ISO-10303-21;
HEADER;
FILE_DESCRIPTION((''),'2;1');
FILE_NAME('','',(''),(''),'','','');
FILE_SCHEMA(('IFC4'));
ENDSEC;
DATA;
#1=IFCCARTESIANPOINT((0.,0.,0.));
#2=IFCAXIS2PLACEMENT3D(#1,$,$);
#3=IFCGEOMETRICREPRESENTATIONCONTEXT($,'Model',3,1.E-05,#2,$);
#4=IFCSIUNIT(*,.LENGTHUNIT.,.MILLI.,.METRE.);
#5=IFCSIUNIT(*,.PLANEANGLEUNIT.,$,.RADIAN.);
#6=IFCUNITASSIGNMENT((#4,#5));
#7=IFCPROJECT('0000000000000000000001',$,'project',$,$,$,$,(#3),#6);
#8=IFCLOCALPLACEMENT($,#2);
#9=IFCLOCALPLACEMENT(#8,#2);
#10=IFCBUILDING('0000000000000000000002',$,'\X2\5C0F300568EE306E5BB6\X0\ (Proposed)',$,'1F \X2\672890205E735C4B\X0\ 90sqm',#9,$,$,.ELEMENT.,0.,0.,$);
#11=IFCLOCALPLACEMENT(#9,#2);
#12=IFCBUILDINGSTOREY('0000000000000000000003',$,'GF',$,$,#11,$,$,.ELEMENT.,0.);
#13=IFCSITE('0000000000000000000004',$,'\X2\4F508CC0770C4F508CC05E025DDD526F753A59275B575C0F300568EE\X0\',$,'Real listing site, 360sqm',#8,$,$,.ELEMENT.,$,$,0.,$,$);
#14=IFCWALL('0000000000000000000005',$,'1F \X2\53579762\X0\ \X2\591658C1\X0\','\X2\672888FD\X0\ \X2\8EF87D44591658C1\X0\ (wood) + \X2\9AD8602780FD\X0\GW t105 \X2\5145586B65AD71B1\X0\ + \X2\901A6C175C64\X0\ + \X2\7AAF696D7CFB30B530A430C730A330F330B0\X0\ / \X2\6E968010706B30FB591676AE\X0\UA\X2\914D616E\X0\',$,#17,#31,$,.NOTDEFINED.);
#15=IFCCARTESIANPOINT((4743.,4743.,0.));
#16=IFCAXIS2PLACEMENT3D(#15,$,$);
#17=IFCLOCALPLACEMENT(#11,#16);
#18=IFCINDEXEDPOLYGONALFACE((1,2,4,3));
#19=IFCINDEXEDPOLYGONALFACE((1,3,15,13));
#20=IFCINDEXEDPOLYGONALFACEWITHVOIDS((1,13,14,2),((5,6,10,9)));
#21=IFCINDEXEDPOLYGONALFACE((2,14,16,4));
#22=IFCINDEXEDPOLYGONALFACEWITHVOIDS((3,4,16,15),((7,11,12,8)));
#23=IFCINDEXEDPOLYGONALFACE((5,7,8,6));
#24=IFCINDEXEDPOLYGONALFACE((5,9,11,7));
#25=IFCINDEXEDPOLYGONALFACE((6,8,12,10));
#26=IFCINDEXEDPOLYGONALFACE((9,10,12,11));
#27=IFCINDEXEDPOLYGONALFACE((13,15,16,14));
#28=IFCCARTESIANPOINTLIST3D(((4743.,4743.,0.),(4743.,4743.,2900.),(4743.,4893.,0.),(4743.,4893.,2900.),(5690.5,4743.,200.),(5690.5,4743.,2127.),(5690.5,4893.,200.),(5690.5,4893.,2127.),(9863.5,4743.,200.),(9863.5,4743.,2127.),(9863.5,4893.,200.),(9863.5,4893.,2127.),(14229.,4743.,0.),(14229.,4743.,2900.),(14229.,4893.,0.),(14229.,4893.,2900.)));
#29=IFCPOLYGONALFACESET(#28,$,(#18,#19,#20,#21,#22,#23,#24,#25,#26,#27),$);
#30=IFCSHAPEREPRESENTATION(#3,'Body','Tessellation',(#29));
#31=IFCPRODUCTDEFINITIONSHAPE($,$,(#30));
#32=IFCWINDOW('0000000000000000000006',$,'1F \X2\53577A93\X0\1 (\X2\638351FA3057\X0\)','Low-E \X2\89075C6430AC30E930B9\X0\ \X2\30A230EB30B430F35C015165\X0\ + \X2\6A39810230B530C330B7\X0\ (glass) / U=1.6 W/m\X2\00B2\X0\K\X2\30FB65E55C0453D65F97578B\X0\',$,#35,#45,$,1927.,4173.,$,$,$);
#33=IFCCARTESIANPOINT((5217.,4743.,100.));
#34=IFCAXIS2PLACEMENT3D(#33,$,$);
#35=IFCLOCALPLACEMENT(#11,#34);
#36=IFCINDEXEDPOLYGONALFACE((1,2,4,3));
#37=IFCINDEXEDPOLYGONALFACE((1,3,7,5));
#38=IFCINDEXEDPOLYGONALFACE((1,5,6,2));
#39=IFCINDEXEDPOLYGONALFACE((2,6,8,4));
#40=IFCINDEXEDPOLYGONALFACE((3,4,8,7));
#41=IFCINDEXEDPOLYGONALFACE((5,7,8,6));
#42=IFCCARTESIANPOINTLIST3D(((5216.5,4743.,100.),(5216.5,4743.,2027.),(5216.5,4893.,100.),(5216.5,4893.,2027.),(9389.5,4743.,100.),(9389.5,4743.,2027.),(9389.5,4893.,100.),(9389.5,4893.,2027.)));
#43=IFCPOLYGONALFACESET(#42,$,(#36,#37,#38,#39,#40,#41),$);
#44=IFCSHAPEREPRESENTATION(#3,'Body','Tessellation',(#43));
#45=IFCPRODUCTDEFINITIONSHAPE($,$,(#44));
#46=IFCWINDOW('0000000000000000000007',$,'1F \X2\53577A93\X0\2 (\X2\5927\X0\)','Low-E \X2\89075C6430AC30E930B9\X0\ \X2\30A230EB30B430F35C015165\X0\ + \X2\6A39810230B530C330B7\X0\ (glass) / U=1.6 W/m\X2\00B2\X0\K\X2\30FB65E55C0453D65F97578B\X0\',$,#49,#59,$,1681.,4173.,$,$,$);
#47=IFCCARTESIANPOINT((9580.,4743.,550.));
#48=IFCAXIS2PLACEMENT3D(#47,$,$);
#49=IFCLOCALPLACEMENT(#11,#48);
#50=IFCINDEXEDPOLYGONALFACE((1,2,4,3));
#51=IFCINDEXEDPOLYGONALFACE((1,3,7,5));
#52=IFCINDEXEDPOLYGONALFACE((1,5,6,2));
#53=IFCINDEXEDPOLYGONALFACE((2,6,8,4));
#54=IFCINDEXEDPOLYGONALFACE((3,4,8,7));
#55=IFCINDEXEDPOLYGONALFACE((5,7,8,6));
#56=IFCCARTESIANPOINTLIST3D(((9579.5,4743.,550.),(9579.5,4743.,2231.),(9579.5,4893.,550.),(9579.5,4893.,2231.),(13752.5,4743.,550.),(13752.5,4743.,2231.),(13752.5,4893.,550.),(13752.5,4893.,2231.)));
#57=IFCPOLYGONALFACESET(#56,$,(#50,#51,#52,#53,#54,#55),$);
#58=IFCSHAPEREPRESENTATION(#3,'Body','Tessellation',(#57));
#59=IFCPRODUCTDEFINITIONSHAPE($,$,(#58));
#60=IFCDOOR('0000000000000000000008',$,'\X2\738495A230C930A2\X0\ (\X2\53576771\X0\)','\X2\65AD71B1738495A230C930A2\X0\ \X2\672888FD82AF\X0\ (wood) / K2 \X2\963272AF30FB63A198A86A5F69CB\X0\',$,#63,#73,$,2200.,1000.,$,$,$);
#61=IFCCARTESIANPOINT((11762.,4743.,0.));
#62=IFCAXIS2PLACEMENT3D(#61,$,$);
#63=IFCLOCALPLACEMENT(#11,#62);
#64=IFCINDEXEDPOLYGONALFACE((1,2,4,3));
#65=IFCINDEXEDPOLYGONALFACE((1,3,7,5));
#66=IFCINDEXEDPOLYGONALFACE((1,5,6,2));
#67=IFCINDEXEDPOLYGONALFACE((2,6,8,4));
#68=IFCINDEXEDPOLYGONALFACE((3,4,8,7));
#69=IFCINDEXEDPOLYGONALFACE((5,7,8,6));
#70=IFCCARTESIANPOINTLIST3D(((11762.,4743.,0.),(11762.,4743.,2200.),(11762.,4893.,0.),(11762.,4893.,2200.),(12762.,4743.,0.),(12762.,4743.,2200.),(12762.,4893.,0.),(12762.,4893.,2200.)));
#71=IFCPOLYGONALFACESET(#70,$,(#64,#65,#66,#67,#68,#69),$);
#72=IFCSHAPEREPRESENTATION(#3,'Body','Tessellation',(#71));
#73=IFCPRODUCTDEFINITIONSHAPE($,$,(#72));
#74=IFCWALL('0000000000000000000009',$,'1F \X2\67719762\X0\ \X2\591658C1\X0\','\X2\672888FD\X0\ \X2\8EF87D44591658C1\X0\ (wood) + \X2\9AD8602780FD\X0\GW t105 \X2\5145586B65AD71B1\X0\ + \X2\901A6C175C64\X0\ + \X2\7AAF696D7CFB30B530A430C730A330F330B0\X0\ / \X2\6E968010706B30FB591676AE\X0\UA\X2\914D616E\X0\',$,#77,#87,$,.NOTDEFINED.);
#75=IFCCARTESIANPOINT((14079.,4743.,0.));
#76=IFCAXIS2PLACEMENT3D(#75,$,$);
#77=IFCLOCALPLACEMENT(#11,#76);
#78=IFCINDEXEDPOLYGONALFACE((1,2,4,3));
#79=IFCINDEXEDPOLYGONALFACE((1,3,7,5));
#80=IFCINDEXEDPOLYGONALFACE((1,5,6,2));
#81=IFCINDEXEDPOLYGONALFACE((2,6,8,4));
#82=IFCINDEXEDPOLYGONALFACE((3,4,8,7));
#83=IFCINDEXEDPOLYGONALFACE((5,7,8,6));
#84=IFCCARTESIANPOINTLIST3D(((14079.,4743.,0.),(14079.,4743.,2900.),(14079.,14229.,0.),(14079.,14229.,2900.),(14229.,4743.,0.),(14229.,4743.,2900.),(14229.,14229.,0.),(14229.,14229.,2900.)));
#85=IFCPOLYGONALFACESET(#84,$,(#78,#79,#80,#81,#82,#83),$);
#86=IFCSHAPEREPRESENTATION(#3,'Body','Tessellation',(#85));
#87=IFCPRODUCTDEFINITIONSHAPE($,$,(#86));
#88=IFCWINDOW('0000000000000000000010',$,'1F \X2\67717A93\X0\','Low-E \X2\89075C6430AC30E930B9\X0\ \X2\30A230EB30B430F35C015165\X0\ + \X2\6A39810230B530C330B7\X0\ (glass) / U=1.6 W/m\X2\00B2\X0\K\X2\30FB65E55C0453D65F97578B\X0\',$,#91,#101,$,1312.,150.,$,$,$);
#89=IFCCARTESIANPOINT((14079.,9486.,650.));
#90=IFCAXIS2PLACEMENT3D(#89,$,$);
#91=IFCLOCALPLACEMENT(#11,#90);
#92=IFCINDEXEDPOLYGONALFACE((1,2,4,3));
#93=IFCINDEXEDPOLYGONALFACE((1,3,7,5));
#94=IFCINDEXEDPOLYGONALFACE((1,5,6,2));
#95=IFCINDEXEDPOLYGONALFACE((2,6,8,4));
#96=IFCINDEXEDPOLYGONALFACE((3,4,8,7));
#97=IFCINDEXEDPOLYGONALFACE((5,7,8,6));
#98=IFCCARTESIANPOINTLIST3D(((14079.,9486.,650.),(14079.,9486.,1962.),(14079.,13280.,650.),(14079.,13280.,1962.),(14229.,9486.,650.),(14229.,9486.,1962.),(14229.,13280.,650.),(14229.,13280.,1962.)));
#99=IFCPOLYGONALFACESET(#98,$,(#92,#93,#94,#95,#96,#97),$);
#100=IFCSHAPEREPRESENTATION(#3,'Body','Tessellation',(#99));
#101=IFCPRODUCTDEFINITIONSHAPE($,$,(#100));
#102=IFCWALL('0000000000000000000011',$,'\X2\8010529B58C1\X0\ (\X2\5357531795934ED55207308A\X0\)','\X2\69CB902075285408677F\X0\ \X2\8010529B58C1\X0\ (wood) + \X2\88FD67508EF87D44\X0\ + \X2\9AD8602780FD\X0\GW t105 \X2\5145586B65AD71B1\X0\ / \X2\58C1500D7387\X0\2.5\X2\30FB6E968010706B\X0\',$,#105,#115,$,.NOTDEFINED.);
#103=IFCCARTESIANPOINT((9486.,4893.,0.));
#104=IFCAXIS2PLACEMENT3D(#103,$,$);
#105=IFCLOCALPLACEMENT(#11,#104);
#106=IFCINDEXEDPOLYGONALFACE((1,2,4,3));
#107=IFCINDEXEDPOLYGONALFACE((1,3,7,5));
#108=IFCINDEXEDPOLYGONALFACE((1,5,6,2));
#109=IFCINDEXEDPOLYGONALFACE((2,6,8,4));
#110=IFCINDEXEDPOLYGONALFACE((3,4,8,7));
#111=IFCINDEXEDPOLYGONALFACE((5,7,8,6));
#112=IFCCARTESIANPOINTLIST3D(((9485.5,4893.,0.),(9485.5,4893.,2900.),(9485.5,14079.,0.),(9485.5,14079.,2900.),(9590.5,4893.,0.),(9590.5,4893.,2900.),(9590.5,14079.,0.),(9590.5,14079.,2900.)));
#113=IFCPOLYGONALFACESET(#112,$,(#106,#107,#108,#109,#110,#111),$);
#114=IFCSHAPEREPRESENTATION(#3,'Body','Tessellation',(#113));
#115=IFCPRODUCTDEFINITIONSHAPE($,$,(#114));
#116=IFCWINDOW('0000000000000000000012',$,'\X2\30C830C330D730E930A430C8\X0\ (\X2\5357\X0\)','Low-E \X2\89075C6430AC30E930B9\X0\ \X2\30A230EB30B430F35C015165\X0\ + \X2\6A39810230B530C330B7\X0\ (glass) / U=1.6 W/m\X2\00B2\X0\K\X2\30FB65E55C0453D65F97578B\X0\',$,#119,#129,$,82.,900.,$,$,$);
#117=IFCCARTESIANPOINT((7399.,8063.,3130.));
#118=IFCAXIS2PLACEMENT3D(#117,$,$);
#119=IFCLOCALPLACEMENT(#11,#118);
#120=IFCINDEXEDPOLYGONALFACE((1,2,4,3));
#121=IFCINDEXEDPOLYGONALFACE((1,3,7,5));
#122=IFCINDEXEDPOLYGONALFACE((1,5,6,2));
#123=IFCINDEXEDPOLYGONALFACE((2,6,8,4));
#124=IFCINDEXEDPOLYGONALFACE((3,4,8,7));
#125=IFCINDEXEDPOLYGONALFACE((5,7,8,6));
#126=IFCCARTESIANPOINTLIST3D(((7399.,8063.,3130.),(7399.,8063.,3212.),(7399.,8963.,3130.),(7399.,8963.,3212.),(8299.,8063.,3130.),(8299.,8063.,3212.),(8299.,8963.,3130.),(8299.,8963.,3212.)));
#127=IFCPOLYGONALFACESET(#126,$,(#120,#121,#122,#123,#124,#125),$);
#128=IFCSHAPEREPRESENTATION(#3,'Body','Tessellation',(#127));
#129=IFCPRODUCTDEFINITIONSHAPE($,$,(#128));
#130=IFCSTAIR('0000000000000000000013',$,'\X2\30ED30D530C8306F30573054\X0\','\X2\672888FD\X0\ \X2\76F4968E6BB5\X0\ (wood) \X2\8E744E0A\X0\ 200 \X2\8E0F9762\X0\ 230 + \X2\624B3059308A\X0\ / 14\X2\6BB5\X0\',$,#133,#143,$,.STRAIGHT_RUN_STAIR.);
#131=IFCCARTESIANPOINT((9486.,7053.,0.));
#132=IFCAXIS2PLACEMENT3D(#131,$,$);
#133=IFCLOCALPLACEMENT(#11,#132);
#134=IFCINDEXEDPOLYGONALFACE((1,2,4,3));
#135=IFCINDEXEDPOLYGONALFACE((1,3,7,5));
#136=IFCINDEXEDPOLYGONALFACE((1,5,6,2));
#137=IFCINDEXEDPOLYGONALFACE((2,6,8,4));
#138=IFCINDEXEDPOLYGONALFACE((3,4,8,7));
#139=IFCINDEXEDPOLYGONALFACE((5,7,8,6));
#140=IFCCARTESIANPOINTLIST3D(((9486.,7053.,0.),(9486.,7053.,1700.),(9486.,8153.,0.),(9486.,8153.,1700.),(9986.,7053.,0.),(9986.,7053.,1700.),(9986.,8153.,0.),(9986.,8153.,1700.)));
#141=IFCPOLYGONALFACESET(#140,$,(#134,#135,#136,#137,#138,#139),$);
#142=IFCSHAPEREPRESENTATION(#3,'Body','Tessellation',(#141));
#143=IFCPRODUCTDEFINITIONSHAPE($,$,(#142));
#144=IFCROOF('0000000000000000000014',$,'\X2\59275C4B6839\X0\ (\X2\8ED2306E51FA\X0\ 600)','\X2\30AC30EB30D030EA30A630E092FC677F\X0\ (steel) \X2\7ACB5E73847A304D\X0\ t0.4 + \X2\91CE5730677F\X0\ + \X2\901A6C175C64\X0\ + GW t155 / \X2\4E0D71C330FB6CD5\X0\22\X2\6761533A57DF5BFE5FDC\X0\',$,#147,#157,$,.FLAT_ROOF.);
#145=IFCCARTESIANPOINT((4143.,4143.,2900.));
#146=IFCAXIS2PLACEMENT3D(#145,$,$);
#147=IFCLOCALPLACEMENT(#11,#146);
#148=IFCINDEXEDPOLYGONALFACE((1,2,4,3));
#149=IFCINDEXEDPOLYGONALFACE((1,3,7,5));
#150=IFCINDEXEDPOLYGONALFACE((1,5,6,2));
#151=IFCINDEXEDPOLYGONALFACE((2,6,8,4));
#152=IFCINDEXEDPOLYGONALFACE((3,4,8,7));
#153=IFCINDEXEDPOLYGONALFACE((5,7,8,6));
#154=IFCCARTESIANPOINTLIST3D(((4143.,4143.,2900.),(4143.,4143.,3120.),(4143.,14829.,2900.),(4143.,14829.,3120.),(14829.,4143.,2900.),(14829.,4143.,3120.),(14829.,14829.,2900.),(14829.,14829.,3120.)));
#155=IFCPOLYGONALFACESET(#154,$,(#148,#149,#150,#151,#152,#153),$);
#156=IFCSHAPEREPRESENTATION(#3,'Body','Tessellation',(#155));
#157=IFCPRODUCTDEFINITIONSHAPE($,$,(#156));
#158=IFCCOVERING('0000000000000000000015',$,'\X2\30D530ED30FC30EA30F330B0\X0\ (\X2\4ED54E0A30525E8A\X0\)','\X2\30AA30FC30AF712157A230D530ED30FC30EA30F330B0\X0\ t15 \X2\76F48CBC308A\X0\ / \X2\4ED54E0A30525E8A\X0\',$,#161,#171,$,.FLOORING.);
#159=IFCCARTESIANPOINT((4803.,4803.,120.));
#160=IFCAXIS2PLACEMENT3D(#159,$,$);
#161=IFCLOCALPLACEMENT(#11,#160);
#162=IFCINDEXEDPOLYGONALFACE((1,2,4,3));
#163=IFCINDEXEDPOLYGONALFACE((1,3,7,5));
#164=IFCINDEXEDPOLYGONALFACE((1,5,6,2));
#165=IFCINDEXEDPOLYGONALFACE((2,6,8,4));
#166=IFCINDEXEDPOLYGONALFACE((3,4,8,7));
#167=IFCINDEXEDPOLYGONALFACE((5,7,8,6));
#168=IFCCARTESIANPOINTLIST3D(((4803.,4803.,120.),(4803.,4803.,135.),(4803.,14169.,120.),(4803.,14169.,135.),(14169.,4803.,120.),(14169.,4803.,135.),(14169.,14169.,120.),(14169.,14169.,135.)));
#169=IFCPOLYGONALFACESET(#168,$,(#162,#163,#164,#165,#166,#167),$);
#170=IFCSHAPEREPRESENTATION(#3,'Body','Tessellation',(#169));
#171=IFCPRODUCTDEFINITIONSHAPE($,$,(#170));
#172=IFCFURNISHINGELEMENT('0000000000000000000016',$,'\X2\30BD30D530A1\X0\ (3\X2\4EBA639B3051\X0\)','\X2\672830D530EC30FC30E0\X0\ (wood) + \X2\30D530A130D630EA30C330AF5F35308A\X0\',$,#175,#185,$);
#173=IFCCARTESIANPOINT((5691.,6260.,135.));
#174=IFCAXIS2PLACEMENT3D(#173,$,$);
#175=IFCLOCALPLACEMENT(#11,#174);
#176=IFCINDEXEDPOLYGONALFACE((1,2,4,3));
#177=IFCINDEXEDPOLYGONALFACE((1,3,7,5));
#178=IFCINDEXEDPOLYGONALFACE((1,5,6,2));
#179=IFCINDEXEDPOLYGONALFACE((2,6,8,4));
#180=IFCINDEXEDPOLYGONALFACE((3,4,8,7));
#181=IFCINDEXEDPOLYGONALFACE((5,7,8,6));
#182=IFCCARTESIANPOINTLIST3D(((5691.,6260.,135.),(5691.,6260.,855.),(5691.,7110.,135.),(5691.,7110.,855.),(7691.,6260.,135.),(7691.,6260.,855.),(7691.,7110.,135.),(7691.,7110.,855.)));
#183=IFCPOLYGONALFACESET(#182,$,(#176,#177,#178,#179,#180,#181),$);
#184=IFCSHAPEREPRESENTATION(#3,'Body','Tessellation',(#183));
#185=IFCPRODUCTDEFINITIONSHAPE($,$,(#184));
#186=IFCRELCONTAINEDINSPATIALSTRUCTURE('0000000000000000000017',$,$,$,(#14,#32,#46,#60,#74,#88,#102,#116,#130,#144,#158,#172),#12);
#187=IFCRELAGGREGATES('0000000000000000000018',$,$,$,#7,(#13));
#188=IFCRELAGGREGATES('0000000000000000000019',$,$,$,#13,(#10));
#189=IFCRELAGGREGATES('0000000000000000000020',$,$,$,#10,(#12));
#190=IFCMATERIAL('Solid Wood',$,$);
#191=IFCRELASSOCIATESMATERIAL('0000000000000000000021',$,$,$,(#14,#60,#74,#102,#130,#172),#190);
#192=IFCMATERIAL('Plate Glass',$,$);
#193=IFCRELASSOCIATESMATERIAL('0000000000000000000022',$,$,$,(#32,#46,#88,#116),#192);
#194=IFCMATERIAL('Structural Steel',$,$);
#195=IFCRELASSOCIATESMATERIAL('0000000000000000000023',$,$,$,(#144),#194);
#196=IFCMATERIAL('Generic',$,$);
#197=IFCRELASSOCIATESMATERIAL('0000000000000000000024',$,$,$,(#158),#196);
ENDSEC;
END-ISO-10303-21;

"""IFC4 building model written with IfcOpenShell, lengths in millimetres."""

from ifc_helpers import new_model, si_unit, frame, frame_2d, origin, place, context, project, spatial, rectangle, extrude, material, element, fill, save


model = new_model("IFC4")

# Units and contexts
model_context = context("Model", 3, precision=1e-05, world=origin())
ifc_project = project(units=[si_unit("LENGTHUNIT", "METRE", prefix="MILLI"), si_unit("PLANEANGLEUNIT", "RADIAN")], contexts=[model_context])

# Site, building, storey
site_placement = place(None, origin())
site = spatial("IfcSite", under=ifc_project, at=site_placement, Name="佐賀県佐賀市川副町大字小々森", ObjectType="Real listing site, 360sqm", CompositionType="ELEMENT", RefElevation=0.0)
building_placement = place(site_placement, origin())
building = spatial("IfcBuilding", under=site, at=building_placement, Name="小々森の家 (Proposed)", ObjectType="1F 木造平屋 90sqm", CompositionType="ELEMENT", ElevationOfRefHeight=0.0, ElevationOfTerrain=0.0)
storey_placement = place(building_placement, origin())
storey = spatial("IfcBuildingStorey", under=building, at=storey_placement, Name="GF", CompositionType="ELEMENT", Elevation=0.0)

# Shared definitions
ifc_material_1 = material(Name="Solid Wood")

# Wall, openings, windows, door
wall_1_placement = place(storey_placement, frame((4743.0, 4743.0, 0.0)))
wall_1 = element("IfcWall", 1, at=wall_1_placement, inside=storey, material=ifc_material_1, Name="1F 南面 外壁", Description="木製 軸組外壁 (wood) + 高性能GW t105 充填断熱 + 通気層 + 窯業系サイディング / 準耐火・外皮UA配慮", PredefinedType="NOTDEFINED", context=model_context, shape_type="SweptSolid", body=[
    extrude(rectangle(XDim=9486.0, YDim=150.0, at=frame_2d((4743.0, 75.0))), frame((4743.0, 4743.0, 0.0)), (0.0, 0.0, 1.0), 2900.0),
])
opening_1_placement = place(storey_placement, frame((5217.0, 4743.0, 100.0)))
opening_1 = element("IfcOpeningElement", 2, at=opening_1_placement, cuts=wall_1, PredefinedType="NOTDEFINED", context=model_context, shape_type="SweptSolid", body=[
    extrude(rectangle(XDim=4173.0, YDim=150.0, at=frame_2d((2086.0, 75.0))), frame((5217.0, 4743.0, 100.0)), (0.0, 0.0, 1.0), 1927.0),
])
opening_2_placement = place(storey_placement, frame((9580.0, 4743.0, 550.0)))
opening_2 = element("IfcOpeningElement", 3, at=opening_2_placement, cuts=wall_1, PredefinedType="NOTDEFINED", context=model_context, shape_type="SweptSolid", body=[
    extrude(rectangle(XDim=4173.0, YDim=150.0, at=frame_2d((2086.0, 75.0))), frame((9580.0, 4743.0, 550.0)), (0.0, 0.0, 1.0), 1681.0),
])
opening_3_placement = place(storey_placement, frame((11762.0, 4743.0, 0.0)))
opening_3 = element("IfcOpeningElement", 4, at=opening_3_placement, cuts=wall_1, PredefinedType="NOTDEFINED", context=model_context, shape_type="SweptSolid", body=[
    extrude(rectangle(XDim=1000.0, YDim=150.0, at=frame_2d((500.0, 75.0))), frame((11762.0, 4743.0, 0.0)), (0.0, 0.0, 1.0), 2200.0),
])
ifc_material_2 = material(Name="Plate Glass")
window_1_placement = place(storey_placement, frame((5217.0, 4743.0, 100.0)))
window_1 = element("IfcWindow", 5, at=window_1_placement, inside=storey, material=ifc_material_2, Name="1F 南窓1 (掃出し)", Description="Low-E 複層ガラス アルゴン封入 + 樹脂サッシ (glass) / U=1.6 W/m²K・日射取得型", OverallHeight=1927.0, OverallWidth=4173.0, context=model_context, shape_type="SweptSolid", body=[
    extrude(rectangle(XDim=4173.0, YDim=150.0, at=frame_2d((2086.0, 75.0))), frame((5217.0, 4743.0, 100.0)), (0.0, 0.0, 1.0), 1927.0),
])
fill(opening_1, window_1)
window_2_placement = place(storey_placement, frame((9580.0, 4743.0, 550.0)))
window_2 = element("IfcWindow", 6, at=window_2_placement, inside=storey, material=ifc_material_2, Name="1F 南窓2 (大)", Description="Low-E 複層ガラス アルゴン封入 + 樹脂サッシ (glass) / U=1.6 W/m²K・日射取得型", OverallHeight=1681.0, OverallWidth=4173.0, context=model_context, shape_type="SweptSolid", body=[
    extrude(rectangle(XDim=4173.0, YDim=150.0, at=frame_2d((2086.0, 75.0))), frame((9580.0, 4743.0, 550.0)), (0.0, 0.0, 1.0), 1681.0),
])
fill(opening_2, window_2)
door_placement = place(storey_placement, frame((11762.0, 4743.0, 0.0)))
door = element("IfcDoor", 7, at=door_placement, inside=storey, material=ifc_material_1, Name="玄関ドア (南東)", Description="断熱玄関ドア 木製芯 (wood) / K2 防犯・採風機構", OverallHeight=2200.0, OverallWidth=1000.0, context=model_context, shape_type="SweptSolid", body=[
    extrude(rectangle(XDim=1000.0, YDim=150.0, at=frame_2d((500.0, 75.0))), frame((11762.0, 4743.0, 0.0)), (0.0, 0.0, 1.0), 2200.0),
])
fill(opening_3, door)

# Wall, opening, window
wall_2_placement = place(storey_placement, frame((14079.0, 4743.0, 0.0)))
wall_2 = element("IfcWall", 8, at=wall_2_placement, inside=storey, material=ifc_material_1, Name="1F 東面 外壁", Description="木製 軸組外壁 (wood) + 高性能GW t105 充填断熱 + 通気層 + 窯業系サイディング / 準耐火・外皮UA配慮", PredefinedType="NOTDEFINED", context=model_context, shape_type="SweptSolid", body=[
    extrude(rectangle(XDim=150.0, YDim=9486.0, at=frame_2d((75.0, 4743.0))), frame((14079.0, 4743.0, 0.0)), (0.0, 0.0, 1.0), 2900.0),
])
opening_4_placement = place(storey_placement, frame((14079.0, 9486.0, 650.0)))
opening_4 = element("IfcOpeningElement", 9, at=opening_4_placement, cuts=wall_2, PredefinedType="NOTDEFINED", context=model_context, shape_type="SweptSolid", body=[
    extrude(rectangle(XDim=150.0, YDim=3794.0, at=frame_2d((75.0, 1897.0))), frame((14079.0, 9486.0, 650.0)), (0.0, 0.0, 1.0), 1312.0),
])
window_3_placement = place(storey_placement, frame((14079.0, 9486.0, 650.0)))
window_3 = element("IfcWindow", 10, at=window_3_placement, inside=storey, material=ifc_material_2, Name="1F 東窓", Description="Low-E 複層ガラス アルゴン封入 + 樹脂サッシ (glass) / U=1.6 W/m²K・日射取得型", OverallHeight=1312.0, OverallWidth=150.0, context=model_context, shape_type="SweptSolid", body=[
    extrude(rectangle(XDim=150.0, YDim=3794.0, at=frame_2d((75.0, 1897.0))), frame((14079.0, 9486.0, 650.0)), (0.0, 0.0, 1.0), 1312.0),
])
fill(opening_4, window_3)

# Wall
wall_3_placement = place(storey_placement, frame((9486.0, 4893.0, 0.0)))
element("IfcWall", 11, at=wall_3_placement, inside=storey, material=ifc_material_1, Name="耐力壁 (南北間仕切り)", Description="構造用合板 耐力壁 (wood) + 製材軸組 + 高性能GW t105 充填断熱 / 壁倍率2.5・準耐火", PredefinedType="NOTDEFINED", context=model_context, shape_type="SweptSolid", body=[
    extrude(rectangle(XDim=105.0, YDim=9186.0, at=frame_2d((52.0, 4593.0))), frame((9486.0, 4893.0, 0.0)), (0.0, 0.0, 1.0), 2900.0),
])

# Window
window_4_placement = place(storey_placement, frame((7399.0, 8063.0, 3130.0)))
element("IfcWindow", 12, at=window_4_placement, inside=storey, material=ifc_material_2, Name="トップライト (南)", Description="Low-E 複層ガラス アルゴン封入 + 樹脂サッシ (glass) / U=1.6 W/m²K・日射取得型", OverallHeight=82.0, OverallWidth=900.0, context=model_context, shape_type="SweptSolid", body=[
    extrude(rectangle(XDim=900.0, YDim=900.0, at=frame_2d((450.0, 450.0))), frame((7399.0, 8063.0, 3130.0)), (0.0, 0.0, 1.0), 82.0),
])

# Stair
stair_placement = place(storey_placement, frame((9486.0, 7053.0, 0.0)))
element("IfcStair", 13, at=stair_placement, inside=storey, material=ifc_material_1, Name="ロフトはしご", Description="木製 直階段 (wood) 蹴上 200 踏面 230 + 手すり / 14段", PredefinedType="STRAIGHT_RUN_STAIR", context=model_context, shape_type="SweptSolid", body=[
    extrude(rectangle(XDim=500.0, YDim=1100.0, at=frame_2d((250.0, 550.0))), frame((9486.0, 7053.0, 0.0)), (0.0, 0.0, 1.0), 1700.0),
])

# Roof
ifc_material_3 = material(Name="Structural Steel")
roof_placement = place(storey_placement, frame((4143.0, 4143.0, 2900.0)))
element("IfcRoof", 14, at=roof_placement, inside=storey, material=ifc_material_3, Name="大屋根 (軒の出 600)", Description="ガルバリウム鋼板 (steel) 立平葺き t0.4 + 野地板 + 通気層 + GW t155 / 不燃・法22条区域対応", PredefinedType="FLAT_ROOF", context=model_context, shape_type="SweptSolid", body=[
    extrude(rectangle(XDim=10686.0, YDim=10686.0, at=frame_2d((5343.0, 5343.0))), frame((4143.0, 4143.0, 2900.0)), (0.0, 0.0, 1.0), 220.0),
])

# Covering
ifc_material_4 = material(Name="Generic")
covering_placement = place(storey_placement, frame((4803.0, 4803.0, 120.0)))
element("IfcCovering", 15, at=covering_placement, inside=storey, material=ifc_material_4, Name="フローリング (仕上げ床)", Description="オーク無垢フローリング t15 直貼り / 仕上げ床", PredefinedType="FLOORING", context=model_context, shape_type="SweptSolid", body=[
    extrude(rectangle(XDim=9366.0, YDim=9366.0, at=frame_2d((4683.0, 4683.0))), frame((4803.0, 4803.0, 120.0)), (0.0, 0.0, 1.0), 15.0),
])

# Furnishing element
furnishing_1_placement = place(storey_placement, frame((5691.0, 6260.0, 135.0)))
element("IfcFurnishingElement", 16, at=furnishing_1_placement, inside=storey, material=ifc_material_1, Name="ソファ (3人掛け)", Description="木フレーム (wood) + ファブリック張り", context=model_context, shape_type="SweptSolid", body=[
    extrude(rectangle(XDim=2000.0, YDim=850.0, at=frame_2d((1000.0, 425.0))), frame((5691.0, 6260.0, 135.0)), (0.0, 0.0, 1.0), 720.0),
])

save(model, "model.ifc")
